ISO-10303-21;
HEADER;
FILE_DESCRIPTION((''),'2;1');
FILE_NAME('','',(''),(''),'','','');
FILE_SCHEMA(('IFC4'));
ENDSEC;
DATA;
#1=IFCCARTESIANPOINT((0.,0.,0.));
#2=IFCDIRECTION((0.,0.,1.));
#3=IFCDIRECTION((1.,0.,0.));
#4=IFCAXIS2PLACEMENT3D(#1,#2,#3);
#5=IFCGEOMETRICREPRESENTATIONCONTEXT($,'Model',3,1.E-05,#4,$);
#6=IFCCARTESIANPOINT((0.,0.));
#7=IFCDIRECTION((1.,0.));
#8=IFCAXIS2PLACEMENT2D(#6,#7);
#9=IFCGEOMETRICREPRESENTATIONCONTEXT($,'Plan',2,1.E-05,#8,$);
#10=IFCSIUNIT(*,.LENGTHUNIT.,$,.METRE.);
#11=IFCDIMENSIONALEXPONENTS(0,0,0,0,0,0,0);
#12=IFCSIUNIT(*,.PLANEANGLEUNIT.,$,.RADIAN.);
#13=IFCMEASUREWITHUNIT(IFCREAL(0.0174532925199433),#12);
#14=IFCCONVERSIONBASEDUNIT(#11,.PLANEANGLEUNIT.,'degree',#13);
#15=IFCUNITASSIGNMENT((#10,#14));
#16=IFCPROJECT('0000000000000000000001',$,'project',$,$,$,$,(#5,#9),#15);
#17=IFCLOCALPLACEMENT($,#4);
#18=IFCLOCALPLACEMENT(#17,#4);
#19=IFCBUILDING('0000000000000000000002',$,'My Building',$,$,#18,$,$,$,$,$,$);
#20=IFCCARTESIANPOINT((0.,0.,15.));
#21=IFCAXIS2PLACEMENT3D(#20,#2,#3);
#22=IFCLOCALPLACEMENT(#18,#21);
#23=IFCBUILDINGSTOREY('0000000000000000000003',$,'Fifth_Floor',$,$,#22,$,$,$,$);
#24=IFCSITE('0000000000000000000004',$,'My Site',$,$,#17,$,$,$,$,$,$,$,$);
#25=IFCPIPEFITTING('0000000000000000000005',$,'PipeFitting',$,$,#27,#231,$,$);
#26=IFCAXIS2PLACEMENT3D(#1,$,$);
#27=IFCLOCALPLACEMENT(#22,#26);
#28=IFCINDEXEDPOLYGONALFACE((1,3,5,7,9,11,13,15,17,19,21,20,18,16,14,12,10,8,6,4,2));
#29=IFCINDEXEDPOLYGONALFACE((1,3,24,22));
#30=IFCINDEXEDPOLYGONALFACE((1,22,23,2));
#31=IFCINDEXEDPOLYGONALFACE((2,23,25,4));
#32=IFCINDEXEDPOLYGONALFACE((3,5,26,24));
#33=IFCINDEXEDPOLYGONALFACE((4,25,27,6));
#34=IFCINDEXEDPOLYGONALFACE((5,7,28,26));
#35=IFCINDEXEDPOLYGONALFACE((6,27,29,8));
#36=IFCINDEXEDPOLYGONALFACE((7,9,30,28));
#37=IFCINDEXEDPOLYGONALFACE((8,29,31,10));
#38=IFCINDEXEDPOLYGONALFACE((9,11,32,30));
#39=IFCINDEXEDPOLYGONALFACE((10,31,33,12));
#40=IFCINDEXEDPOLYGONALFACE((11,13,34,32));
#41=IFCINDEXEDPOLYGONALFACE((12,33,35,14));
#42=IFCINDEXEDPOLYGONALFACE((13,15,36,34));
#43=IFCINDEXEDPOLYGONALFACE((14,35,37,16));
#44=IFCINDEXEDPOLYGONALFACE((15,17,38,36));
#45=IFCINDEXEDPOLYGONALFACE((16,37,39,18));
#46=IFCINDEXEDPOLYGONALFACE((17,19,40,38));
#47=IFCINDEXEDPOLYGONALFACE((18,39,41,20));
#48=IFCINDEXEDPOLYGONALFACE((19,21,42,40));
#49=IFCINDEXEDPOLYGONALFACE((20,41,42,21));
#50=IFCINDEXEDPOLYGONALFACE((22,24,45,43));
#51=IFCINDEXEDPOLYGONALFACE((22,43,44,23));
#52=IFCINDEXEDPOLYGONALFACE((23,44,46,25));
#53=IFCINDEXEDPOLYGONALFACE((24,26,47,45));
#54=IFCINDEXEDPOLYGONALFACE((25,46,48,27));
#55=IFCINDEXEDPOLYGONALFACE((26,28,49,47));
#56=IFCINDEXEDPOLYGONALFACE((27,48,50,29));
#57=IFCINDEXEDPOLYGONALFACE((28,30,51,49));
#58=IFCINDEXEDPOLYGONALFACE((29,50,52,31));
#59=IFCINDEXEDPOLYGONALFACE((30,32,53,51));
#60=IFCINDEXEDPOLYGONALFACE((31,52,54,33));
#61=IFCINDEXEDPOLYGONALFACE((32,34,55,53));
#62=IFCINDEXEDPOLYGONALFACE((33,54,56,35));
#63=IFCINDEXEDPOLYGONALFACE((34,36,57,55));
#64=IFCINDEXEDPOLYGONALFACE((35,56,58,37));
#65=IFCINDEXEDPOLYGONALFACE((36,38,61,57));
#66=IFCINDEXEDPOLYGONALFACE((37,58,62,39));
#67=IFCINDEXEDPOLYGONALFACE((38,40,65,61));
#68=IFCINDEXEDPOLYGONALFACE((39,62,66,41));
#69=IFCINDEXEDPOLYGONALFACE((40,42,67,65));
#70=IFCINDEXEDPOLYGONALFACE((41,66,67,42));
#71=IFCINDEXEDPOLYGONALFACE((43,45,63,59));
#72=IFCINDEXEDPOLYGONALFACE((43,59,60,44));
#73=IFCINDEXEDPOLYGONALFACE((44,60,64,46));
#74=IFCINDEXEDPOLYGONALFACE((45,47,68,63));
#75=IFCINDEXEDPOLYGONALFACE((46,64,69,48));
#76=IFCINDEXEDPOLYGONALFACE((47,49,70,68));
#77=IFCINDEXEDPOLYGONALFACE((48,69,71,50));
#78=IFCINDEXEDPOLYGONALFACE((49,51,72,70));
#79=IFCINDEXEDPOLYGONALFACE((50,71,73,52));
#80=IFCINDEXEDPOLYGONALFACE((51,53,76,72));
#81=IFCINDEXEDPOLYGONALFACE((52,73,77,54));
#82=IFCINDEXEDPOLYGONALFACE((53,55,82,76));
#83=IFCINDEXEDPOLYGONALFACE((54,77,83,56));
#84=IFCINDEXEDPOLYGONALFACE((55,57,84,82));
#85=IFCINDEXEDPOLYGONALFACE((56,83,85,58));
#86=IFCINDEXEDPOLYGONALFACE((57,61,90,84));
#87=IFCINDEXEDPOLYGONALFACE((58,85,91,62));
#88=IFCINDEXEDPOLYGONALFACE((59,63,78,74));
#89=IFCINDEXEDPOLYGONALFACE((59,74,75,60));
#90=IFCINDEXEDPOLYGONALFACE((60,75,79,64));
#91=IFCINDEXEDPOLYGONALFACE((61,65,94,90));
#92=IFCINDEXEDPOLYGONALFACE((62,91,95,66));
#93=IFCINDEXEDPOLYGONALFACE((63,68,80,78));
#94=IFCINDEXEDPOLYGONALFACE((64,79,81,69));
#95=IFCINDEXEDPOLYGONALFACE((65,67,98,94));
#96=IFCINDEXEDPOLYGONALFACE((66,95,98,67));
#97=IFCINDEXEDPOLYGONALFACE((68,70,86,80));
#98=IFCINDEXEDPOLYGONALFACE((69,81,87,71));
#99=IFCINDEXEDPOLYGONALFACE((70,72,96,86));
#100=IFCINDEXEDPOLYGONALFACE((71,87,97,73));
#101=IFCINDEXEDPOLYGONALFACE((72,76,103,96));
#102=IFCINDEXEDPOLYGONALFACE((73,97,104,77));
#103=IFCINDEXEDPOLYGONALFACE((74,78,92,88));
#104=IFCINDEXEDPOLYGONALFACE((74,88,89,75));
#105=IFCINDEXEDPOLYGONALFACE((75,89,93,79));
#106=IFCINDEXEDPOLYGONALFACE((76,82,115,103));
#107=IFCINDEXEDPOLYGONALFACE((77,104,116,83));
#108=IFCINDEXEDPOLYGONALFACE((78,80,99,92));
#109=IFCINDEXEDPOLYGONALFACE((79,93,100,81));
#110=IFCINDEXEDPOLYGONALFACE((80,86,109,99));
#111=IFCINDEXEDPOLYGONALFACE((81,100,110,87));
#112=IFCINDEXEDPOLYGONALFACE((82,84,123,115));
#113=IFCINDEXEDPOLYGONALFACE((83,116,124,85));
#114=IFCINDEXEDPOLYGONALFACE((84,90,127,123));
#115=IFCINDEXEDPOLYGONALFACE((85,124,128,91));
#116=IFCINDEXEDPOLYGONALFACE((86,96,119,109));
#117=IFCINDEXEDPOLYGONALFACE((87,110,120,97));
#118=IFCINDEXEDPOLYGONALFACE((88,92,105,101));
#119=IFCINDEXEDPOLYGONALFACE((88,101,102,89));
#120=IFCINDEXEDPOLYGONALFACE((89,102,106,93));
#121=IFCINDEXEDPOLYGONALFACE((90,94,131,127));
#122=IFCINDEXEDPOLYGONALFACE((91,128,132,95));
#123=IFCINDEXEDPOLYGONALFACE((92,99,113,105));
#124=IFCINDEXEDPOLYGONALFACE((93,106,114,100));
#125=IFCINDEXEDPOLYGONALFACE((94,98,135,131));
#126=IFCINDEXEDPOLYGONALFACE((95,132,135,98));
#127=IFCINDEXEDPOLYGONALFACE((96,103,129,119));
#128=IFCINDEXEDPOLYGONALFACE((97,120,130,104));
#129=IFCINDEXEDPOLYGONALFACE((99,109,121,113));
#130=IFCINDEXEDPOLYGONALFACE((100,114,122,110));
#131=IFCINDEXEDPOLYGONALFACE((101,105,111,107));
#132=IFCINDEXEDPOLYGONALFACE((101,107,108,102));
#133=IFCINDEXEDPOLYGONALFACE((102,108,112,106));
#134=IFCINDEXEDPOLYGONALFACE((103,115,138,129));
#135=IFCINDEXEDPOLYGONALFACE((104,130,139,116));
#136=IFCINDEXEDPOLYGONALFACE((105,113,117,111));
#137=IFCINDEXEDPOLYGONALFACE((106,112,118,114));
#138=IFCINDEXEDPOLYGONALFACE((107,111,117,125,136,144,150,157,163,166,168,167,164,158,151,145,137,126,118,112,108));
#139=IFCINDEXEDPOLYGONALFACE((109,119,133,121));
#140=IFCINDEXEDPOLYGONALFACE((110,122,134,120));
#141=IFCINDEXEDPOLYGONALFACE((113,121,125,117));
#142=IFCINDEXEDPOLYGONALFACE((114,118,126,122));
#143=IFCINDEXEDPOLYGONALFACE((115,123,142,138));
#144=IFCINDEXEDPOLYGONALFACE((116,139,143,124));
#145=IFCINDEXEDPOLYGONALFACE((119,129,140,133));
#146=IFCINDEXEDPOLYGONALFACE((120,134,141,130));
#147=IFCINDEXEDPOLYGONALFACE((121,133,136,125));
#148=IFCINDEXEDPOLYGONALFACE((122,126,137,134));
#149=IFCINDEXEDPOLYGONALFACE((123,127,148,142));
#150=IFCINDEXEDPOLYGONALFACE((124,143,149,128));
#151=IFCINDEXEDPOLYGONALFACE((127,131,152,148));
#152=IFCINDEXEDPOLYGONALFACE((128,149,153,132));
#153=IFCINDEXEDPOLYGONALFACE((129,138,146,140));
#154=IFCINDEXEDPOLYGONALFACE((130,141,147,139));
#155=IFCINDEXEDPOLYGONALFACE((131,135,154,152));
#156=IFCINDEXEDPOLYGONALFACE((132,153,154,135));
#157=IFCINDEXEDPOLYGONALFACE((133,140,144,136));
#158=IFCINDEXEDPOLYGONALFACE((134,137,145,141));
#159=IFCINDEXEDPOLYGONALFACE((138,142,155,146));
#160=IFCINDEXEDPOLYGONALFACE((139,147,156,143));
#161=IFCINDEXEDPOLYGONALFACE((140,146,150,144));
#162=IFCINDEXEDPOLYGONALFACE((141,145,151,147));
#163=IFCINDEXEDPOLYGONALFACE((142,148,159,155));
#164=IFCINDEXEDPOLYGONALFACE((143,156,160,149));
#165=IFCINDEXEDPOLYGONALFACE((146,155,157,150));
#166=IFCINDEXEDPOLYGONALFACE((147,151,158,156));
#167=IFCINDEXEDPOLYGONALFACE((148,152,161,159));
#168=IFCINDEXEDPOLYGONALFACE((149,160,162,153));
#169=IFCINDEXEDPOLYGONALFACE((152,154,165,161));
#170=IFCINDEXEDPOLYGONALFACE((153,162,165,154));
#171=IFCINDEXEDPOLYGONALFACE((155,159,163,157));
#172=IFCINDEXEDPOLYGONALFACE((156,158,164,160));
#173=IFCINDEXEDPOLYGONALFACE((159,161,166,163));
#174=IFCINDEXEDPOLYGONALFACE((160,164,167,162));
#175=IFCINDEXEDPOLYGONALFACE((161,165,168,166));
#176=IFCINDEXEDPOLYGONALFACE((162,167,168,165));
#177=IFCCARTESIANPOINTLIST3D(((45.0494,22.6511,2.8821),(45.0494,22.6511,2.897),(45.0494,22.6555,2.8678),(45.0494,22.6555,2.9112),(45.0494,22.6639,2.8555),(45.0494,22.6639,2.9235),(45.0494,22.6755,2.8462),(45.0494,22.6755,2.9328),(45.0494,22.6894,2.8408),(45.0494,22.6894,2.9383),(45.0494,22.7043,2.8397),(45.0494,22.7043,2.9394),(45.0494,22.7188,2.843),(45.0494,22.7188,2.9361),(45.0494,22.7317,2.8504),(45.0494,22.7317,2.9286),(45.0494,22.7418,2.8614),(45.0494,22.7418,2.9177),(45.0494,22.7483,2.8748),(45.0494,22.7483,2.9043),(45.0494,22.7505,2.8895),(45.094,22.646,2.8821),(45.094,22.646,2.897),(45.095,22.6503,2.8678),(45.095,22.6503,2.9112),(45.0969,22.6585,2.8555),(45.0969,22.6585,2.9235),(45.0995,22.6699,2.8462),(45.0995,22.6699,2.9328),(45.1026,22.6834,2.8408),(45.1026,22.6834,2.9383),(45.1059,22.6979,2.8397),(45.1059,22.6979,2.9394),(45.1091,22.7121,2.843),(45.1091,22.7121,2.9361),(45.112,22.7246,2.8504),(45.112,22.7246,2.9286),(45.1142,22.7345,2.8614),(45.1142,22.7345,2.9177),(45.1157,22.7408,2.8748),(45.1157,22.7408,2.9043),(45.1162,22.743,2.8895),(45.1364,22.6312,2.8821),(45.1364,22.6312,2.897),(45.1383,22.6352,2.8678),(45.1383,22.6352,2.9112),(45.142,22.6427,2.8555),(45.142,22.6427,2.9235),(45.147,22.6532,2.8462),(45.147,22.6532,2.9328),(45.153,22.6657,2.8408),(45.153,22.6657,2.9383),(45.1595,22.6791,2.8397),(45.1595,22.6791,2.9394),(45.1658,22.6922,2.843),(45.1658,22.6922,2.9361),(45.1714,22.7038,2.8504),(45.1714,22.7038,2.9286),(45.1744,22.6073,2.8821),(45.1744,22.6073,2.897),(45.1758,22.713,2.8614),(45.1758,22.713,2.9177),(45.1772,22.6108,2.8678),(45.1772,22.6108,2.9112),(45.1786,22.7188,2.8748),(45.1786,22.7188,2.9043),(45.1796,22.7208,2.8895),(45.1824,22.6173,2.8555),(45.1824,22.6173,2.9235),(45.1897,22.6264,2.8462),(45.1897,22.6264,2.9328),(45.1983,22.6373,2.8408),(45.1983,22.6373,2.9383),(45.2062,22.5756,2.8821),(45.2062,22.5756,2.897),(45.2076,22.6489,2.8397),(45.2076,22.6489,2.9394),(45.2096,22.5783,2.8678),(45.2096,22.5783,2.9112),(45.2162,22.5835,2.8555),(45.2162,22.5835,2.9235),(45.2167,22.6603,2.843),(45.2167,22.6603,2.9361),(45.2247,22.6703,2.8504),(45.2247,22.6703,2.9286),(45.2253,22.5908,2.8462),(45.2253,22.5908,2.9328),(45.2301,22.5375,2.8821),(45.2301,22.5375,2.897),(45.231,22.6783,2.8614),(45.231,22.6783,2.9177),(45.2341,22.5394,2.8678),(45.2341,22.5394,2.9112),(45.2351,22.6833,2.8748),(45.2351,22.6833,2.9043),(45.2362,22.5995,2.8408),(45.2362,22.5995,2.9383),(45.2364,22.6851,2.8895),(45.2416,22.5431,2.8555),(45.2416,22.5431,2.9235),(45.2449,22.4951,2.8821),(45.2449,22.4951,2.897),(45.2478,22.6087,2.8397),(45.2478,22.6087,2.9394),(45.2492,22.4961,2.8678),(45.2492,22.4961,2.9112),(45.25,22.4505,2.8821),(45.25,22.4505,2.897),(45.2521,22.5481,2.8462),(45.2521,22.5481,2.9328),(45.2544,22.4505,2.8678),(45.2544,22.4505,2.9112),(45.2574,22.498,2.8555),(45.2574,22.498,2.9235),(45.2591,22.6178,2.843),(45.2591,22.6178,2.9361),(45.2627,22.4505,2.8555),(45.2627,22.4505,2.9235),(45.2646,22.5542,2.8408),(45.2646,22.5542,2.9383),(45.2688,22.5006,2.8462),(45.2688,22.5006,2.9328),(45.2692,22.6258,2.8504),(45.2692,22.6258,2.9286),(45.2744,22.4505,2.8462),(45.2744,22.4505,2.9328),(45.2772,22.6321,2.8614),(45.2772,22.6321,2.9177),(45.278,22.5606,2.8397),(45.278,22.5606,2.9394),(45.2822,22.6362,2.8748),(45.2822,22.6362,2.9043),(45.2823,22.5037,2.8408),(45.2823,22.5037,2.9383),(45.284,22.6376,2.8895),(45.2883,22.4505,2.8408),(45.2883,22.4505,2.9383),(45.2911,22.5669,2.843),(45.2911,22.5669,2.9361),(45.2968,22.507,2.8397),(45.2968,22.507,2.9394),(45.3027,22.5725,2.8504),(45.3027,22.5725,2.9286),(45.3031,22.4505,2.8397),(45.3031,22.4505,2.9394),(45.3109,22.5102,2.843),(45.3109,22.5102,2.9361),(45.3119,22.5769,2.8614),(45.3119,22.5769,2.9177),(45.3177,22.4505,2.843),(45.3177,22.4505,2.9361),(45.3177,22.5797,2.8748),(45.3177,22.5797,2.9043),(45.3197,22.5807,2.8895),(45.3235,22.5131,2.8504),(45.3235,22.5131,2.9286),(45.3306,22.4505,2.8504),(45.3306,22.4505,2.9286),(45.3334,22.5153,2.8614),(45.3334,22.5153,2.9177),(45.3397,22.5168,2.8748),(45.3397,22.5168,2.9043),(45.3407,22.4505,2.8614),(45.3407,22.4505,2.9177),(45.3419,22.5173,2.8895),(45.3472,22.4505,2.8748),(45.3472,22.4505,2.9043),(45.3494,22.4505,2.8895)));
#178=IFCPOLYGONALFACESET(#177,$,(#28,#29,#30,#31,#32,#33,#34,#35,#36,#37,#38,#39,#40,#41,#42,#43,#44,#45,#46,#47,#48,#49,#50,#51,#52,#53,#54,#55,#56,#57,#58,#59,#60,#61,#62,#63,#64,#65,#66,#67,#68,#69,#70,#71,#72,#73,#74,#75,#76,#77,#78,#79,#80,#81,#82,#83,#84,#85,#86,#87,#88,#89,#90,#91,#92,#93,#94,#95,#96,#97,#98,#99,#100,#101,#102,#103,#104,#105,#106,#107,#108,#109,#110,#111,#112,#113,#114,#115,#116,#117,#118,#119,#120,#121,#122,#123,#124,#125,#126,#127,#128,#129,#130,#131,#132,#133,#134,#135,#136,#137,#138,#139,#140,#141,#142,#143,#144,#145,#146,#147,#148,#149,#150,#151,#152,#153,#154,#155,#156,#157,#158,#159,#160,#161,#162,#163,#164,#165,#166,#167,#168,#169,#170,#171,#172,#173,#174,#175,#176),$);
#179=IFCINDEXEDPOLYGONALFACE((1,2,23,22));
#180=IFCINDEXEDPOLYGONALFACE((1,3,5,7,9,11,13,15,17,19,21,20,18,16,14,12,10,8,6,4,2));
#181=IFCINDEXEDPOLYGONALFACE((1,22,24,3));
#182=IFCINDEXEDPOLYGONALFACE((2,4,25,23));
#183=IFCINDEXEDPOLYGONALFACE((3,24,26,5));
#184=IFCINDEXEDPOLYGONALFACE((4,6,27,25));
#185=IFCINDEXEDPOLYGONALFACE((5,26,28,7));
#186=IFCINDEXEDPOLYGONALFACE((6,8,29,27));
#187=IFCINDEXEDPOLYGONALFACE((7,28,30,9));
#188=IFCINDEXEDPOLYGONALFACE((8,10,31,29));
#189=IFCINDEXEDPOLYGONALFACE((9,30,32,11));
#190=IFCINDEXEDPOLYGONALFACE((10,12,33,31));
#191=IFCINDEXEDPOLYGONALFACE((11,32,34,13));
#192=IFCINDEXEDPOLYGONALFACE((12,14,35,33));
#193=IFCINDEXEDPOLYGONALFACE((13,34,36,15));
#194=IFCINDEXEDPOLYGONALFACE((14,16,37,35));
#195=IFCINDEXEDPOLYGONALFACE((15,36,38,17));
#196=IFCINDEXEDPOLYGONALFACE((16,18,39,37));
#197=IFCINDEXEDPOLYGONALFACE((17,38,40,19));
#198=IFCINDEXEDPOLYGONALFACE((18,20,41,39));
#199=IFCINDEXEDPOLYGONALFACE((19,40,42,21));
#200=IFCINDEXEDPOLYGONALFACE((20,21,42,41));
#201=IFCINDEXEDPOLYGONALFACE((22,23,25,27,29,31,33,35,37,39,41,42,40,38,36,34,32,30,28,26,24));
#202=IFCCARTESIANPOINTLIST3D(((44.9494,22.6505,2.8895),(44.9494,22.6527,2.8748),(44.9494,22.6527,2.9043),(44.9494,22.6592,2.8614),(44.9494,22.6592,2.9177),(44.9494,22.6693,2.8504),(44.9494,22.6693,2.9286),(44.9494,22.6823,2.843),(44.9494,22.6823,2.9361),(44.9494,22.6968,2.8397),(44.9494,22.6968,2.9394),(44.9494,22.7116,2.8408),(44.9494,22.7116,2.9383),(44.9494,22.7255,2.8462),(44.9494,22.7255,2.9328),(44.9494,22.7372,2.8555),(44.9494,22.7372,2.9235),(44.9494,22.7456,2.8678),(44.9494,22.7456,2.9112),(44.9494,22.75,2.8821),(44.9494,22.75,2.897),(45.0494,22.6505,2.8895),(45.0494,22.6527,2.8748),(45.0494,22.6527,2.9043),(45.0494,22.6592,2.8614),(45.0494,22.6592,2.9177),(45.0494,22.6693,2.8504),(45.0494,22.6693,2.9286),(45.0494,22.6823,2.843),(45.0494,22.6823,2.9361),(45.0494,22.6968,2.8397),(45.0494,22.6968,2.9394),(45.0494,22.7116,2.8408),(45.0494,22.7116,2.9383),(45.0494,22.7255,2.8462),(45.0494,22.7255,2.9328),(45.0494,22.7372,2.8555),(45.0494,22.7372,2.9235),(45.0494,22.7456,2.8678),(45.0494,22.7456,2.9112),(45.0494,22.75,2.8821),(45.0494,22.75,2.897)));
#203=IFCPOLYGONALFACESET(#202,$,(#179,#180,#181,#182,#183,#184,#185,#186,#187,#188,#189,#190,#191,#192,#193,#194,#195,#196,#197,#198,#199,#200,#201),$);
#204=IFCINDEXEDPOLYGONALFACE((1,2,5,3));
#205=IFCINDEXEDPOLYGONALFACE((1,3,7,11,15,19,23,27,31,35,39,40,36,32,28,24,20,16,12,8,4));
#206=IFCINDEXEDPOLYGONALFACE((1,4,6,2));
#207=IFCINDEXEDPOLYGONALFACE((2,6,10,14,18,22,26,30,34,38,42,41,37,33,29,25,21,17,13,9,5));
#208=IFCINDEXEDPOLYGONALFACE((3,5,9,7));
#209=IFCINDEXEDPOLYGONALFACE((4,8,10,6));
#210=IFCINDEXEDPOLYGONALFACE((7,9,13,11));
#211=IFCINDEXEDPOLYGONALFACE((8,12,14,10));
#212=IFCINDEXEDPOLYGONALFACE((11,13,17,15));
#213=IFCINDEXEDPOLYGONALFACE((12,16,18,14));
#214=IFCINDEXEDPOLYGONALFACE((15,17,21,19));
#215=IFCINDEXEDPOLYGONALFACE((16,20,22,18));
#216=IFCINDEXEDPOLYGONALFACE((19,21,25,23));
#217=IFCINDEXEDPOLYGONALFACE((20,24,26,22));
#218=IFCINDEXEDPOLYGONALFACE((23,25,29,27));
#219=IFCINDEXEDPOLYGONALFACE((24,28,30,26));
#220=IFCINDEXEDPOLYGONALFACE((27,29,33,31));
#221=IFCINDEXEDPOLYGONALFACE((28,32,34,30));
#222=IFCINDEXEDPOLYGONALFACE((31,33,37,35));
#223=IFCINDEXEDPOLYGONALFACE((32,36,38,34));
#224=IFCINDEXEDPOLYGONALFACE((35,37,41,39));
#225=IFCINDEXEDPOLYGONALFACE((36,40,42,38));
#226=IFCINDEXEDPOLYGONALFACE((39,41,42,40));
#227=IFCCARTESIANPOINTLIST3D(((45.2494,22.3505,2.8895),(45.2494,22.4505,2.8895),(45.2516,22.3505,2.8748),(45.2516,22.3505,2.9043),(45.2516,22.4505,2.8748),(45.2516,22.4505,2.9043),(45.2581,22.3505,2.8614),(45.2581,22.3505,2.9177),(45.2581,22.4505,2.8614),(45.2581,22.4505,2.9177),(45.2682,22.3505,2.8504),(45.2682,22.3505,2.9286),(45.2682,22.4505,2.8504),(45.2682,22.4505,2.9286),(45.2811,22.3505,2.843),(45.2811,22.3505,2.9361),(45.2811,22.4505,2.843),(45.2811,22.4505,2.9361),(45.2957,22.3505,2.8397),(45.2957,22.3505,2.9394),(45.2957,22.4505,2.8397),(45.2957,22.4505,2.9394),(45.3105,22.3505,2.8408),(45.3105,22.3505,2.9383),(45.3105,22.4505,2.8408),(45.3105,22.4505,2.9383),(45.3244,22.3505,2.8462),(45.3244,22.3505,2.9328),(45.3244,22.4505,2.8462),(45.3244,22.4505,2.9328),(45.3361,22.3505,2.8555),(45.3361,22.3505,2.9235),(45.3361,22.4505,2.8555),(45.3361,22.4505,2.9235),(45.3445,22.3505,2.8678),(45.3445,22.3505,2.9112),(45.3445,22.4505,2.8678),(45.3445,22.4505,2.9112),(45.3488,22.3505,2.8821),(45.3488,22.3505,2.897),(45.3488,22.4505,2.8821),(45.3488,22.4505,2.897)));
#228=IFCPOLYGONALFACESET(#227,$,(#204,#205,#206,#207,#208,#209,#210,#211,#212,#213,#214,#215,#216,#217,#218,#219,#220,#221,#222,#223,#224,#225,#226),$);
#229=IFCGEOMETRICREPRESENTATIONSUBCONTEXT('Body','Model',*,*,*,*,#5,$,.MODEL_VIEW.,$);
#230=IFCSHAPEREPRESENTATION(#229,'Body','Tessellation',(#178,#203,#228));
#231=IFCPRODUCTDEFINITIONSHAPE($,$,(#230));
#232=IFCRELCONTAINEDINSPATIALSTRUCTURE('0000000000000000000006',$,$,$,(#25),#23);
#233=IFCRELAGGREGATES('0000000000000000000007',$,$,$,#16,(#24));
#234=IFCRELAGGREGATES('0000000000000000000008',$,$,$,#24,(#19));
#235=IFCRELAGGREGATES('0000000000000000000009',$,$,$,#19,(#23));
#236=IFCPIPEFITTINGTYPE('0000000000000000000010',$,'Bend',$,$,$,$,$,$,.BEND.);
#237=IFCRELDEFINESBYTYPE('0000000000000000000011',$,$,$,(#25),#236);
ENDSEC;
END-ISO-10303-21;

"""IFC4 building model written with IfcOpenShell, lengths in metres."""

from ifc_helpers import new_model, entity, si_unit, converted_unit, frame, origin_with_axes, origin_2d_with_axis, place, context, subcontext, project, spatial, circle, extrude, source, transform, mapped, type_object, type_shapes, element, save


model = new_model("IFC4")

# Units and contexts
model_context = context("Model", 3, precision=1e-05, world=origin_with_axes())
plan_context = context("Plan", 2, precision=1e-05, world=origin_2d_with_axis())
body_context_1 = subcontext(model_context, "Body", "Model", "MODEL_VIEW")
ifc_project = project(units=[si_unit("LENGTHUNIT", "METRE"), converted_unit("PLANEANGLEUNIT", "degree", entity("IfcReal", 0.0174532925199433), si_unit("PLANEANGLEUNIT", "RADIAN"), dimensions=[0, 0, 0, 0, 0, 0, 0])], contexts=[model_context, plan_context])

# Site, building, storey
site_placement = place(None, origin_with_axes())
site = spatial("IfcSite", under=ifc_project, at=site_placement, Name="My Site")
building_placement = place(site_placement, origin_with_axes())
building = spatial("IfcBuilding", under=site, at=building_placement, Name="My Building")
storey_placement = place(building_placement, frame((0.0, 0.0, 15.0), z_axis=(0.0, 0.0, 1.0), x_axis=(1.0, 0.0, 0.0)))
storey = spatial("IfcBuildingStorey", under=building, at=storey_placement, Name="Fifth_Floor")

# Pipe fitting
pipe_fitting_type = type_object("IfcPipeFittingType", Name="Bend", PredefinedType="BEND")
shared_shape_1 = source(origin_with_axes(), body_context_1, "Body", "SolidModel", [
    entity("IfcSweptDiskSolid", entity("IfcIndexedPolyCurve", entity("IfcCartesianPointList3D", [[0.0, 0.0, -0.1], [0.0732, 0.0, -0.2768], [0.25, 0.0, -0.35]]), [entity("IfcArcIndex", [1, 2, 3])]), 0.05),
    extrude(circle(Radius=0.05), origin_with_axes(), (0.0, 0.0, -1.0), 0.1),
    extrude(circle(Radius=0.05), frame((0.25, 0.0, -0.35), z_axis=(1.0, 0.0, 0.0), x_axis=(0.0, 0.0, 1.0)), (0.0, 0.0, 1.0), 0.1),
])
type_shapes(pipe_fitting_type, [shared_shape_1])
pipe_fitting_placement = place(storey_placement, frame((44.9494, 22.7005, 2.8895), z_axis=(-1.0, -0.000001, 0.0), x_axis=(0.000001, -1.0, -0.000001)))
element("IfcPipeFitting", 1, at=pipe_fitting_placement, inside=storey, type_object=pipe_fitting_type, Name="PipeFitting", context=body_context_1, shape_type="MappedRepresentation", body=[
    mapped(shared_shape_1, transform((0.0, 0.0, 0.0), x_axis=(1.0, 0.0, 0.0), y_axis=(0.0, 1.0, 0.0), z_axis=(0.0, 0.0, 1.0), scale=1.0)),
])

save(model, "model.ifc")
